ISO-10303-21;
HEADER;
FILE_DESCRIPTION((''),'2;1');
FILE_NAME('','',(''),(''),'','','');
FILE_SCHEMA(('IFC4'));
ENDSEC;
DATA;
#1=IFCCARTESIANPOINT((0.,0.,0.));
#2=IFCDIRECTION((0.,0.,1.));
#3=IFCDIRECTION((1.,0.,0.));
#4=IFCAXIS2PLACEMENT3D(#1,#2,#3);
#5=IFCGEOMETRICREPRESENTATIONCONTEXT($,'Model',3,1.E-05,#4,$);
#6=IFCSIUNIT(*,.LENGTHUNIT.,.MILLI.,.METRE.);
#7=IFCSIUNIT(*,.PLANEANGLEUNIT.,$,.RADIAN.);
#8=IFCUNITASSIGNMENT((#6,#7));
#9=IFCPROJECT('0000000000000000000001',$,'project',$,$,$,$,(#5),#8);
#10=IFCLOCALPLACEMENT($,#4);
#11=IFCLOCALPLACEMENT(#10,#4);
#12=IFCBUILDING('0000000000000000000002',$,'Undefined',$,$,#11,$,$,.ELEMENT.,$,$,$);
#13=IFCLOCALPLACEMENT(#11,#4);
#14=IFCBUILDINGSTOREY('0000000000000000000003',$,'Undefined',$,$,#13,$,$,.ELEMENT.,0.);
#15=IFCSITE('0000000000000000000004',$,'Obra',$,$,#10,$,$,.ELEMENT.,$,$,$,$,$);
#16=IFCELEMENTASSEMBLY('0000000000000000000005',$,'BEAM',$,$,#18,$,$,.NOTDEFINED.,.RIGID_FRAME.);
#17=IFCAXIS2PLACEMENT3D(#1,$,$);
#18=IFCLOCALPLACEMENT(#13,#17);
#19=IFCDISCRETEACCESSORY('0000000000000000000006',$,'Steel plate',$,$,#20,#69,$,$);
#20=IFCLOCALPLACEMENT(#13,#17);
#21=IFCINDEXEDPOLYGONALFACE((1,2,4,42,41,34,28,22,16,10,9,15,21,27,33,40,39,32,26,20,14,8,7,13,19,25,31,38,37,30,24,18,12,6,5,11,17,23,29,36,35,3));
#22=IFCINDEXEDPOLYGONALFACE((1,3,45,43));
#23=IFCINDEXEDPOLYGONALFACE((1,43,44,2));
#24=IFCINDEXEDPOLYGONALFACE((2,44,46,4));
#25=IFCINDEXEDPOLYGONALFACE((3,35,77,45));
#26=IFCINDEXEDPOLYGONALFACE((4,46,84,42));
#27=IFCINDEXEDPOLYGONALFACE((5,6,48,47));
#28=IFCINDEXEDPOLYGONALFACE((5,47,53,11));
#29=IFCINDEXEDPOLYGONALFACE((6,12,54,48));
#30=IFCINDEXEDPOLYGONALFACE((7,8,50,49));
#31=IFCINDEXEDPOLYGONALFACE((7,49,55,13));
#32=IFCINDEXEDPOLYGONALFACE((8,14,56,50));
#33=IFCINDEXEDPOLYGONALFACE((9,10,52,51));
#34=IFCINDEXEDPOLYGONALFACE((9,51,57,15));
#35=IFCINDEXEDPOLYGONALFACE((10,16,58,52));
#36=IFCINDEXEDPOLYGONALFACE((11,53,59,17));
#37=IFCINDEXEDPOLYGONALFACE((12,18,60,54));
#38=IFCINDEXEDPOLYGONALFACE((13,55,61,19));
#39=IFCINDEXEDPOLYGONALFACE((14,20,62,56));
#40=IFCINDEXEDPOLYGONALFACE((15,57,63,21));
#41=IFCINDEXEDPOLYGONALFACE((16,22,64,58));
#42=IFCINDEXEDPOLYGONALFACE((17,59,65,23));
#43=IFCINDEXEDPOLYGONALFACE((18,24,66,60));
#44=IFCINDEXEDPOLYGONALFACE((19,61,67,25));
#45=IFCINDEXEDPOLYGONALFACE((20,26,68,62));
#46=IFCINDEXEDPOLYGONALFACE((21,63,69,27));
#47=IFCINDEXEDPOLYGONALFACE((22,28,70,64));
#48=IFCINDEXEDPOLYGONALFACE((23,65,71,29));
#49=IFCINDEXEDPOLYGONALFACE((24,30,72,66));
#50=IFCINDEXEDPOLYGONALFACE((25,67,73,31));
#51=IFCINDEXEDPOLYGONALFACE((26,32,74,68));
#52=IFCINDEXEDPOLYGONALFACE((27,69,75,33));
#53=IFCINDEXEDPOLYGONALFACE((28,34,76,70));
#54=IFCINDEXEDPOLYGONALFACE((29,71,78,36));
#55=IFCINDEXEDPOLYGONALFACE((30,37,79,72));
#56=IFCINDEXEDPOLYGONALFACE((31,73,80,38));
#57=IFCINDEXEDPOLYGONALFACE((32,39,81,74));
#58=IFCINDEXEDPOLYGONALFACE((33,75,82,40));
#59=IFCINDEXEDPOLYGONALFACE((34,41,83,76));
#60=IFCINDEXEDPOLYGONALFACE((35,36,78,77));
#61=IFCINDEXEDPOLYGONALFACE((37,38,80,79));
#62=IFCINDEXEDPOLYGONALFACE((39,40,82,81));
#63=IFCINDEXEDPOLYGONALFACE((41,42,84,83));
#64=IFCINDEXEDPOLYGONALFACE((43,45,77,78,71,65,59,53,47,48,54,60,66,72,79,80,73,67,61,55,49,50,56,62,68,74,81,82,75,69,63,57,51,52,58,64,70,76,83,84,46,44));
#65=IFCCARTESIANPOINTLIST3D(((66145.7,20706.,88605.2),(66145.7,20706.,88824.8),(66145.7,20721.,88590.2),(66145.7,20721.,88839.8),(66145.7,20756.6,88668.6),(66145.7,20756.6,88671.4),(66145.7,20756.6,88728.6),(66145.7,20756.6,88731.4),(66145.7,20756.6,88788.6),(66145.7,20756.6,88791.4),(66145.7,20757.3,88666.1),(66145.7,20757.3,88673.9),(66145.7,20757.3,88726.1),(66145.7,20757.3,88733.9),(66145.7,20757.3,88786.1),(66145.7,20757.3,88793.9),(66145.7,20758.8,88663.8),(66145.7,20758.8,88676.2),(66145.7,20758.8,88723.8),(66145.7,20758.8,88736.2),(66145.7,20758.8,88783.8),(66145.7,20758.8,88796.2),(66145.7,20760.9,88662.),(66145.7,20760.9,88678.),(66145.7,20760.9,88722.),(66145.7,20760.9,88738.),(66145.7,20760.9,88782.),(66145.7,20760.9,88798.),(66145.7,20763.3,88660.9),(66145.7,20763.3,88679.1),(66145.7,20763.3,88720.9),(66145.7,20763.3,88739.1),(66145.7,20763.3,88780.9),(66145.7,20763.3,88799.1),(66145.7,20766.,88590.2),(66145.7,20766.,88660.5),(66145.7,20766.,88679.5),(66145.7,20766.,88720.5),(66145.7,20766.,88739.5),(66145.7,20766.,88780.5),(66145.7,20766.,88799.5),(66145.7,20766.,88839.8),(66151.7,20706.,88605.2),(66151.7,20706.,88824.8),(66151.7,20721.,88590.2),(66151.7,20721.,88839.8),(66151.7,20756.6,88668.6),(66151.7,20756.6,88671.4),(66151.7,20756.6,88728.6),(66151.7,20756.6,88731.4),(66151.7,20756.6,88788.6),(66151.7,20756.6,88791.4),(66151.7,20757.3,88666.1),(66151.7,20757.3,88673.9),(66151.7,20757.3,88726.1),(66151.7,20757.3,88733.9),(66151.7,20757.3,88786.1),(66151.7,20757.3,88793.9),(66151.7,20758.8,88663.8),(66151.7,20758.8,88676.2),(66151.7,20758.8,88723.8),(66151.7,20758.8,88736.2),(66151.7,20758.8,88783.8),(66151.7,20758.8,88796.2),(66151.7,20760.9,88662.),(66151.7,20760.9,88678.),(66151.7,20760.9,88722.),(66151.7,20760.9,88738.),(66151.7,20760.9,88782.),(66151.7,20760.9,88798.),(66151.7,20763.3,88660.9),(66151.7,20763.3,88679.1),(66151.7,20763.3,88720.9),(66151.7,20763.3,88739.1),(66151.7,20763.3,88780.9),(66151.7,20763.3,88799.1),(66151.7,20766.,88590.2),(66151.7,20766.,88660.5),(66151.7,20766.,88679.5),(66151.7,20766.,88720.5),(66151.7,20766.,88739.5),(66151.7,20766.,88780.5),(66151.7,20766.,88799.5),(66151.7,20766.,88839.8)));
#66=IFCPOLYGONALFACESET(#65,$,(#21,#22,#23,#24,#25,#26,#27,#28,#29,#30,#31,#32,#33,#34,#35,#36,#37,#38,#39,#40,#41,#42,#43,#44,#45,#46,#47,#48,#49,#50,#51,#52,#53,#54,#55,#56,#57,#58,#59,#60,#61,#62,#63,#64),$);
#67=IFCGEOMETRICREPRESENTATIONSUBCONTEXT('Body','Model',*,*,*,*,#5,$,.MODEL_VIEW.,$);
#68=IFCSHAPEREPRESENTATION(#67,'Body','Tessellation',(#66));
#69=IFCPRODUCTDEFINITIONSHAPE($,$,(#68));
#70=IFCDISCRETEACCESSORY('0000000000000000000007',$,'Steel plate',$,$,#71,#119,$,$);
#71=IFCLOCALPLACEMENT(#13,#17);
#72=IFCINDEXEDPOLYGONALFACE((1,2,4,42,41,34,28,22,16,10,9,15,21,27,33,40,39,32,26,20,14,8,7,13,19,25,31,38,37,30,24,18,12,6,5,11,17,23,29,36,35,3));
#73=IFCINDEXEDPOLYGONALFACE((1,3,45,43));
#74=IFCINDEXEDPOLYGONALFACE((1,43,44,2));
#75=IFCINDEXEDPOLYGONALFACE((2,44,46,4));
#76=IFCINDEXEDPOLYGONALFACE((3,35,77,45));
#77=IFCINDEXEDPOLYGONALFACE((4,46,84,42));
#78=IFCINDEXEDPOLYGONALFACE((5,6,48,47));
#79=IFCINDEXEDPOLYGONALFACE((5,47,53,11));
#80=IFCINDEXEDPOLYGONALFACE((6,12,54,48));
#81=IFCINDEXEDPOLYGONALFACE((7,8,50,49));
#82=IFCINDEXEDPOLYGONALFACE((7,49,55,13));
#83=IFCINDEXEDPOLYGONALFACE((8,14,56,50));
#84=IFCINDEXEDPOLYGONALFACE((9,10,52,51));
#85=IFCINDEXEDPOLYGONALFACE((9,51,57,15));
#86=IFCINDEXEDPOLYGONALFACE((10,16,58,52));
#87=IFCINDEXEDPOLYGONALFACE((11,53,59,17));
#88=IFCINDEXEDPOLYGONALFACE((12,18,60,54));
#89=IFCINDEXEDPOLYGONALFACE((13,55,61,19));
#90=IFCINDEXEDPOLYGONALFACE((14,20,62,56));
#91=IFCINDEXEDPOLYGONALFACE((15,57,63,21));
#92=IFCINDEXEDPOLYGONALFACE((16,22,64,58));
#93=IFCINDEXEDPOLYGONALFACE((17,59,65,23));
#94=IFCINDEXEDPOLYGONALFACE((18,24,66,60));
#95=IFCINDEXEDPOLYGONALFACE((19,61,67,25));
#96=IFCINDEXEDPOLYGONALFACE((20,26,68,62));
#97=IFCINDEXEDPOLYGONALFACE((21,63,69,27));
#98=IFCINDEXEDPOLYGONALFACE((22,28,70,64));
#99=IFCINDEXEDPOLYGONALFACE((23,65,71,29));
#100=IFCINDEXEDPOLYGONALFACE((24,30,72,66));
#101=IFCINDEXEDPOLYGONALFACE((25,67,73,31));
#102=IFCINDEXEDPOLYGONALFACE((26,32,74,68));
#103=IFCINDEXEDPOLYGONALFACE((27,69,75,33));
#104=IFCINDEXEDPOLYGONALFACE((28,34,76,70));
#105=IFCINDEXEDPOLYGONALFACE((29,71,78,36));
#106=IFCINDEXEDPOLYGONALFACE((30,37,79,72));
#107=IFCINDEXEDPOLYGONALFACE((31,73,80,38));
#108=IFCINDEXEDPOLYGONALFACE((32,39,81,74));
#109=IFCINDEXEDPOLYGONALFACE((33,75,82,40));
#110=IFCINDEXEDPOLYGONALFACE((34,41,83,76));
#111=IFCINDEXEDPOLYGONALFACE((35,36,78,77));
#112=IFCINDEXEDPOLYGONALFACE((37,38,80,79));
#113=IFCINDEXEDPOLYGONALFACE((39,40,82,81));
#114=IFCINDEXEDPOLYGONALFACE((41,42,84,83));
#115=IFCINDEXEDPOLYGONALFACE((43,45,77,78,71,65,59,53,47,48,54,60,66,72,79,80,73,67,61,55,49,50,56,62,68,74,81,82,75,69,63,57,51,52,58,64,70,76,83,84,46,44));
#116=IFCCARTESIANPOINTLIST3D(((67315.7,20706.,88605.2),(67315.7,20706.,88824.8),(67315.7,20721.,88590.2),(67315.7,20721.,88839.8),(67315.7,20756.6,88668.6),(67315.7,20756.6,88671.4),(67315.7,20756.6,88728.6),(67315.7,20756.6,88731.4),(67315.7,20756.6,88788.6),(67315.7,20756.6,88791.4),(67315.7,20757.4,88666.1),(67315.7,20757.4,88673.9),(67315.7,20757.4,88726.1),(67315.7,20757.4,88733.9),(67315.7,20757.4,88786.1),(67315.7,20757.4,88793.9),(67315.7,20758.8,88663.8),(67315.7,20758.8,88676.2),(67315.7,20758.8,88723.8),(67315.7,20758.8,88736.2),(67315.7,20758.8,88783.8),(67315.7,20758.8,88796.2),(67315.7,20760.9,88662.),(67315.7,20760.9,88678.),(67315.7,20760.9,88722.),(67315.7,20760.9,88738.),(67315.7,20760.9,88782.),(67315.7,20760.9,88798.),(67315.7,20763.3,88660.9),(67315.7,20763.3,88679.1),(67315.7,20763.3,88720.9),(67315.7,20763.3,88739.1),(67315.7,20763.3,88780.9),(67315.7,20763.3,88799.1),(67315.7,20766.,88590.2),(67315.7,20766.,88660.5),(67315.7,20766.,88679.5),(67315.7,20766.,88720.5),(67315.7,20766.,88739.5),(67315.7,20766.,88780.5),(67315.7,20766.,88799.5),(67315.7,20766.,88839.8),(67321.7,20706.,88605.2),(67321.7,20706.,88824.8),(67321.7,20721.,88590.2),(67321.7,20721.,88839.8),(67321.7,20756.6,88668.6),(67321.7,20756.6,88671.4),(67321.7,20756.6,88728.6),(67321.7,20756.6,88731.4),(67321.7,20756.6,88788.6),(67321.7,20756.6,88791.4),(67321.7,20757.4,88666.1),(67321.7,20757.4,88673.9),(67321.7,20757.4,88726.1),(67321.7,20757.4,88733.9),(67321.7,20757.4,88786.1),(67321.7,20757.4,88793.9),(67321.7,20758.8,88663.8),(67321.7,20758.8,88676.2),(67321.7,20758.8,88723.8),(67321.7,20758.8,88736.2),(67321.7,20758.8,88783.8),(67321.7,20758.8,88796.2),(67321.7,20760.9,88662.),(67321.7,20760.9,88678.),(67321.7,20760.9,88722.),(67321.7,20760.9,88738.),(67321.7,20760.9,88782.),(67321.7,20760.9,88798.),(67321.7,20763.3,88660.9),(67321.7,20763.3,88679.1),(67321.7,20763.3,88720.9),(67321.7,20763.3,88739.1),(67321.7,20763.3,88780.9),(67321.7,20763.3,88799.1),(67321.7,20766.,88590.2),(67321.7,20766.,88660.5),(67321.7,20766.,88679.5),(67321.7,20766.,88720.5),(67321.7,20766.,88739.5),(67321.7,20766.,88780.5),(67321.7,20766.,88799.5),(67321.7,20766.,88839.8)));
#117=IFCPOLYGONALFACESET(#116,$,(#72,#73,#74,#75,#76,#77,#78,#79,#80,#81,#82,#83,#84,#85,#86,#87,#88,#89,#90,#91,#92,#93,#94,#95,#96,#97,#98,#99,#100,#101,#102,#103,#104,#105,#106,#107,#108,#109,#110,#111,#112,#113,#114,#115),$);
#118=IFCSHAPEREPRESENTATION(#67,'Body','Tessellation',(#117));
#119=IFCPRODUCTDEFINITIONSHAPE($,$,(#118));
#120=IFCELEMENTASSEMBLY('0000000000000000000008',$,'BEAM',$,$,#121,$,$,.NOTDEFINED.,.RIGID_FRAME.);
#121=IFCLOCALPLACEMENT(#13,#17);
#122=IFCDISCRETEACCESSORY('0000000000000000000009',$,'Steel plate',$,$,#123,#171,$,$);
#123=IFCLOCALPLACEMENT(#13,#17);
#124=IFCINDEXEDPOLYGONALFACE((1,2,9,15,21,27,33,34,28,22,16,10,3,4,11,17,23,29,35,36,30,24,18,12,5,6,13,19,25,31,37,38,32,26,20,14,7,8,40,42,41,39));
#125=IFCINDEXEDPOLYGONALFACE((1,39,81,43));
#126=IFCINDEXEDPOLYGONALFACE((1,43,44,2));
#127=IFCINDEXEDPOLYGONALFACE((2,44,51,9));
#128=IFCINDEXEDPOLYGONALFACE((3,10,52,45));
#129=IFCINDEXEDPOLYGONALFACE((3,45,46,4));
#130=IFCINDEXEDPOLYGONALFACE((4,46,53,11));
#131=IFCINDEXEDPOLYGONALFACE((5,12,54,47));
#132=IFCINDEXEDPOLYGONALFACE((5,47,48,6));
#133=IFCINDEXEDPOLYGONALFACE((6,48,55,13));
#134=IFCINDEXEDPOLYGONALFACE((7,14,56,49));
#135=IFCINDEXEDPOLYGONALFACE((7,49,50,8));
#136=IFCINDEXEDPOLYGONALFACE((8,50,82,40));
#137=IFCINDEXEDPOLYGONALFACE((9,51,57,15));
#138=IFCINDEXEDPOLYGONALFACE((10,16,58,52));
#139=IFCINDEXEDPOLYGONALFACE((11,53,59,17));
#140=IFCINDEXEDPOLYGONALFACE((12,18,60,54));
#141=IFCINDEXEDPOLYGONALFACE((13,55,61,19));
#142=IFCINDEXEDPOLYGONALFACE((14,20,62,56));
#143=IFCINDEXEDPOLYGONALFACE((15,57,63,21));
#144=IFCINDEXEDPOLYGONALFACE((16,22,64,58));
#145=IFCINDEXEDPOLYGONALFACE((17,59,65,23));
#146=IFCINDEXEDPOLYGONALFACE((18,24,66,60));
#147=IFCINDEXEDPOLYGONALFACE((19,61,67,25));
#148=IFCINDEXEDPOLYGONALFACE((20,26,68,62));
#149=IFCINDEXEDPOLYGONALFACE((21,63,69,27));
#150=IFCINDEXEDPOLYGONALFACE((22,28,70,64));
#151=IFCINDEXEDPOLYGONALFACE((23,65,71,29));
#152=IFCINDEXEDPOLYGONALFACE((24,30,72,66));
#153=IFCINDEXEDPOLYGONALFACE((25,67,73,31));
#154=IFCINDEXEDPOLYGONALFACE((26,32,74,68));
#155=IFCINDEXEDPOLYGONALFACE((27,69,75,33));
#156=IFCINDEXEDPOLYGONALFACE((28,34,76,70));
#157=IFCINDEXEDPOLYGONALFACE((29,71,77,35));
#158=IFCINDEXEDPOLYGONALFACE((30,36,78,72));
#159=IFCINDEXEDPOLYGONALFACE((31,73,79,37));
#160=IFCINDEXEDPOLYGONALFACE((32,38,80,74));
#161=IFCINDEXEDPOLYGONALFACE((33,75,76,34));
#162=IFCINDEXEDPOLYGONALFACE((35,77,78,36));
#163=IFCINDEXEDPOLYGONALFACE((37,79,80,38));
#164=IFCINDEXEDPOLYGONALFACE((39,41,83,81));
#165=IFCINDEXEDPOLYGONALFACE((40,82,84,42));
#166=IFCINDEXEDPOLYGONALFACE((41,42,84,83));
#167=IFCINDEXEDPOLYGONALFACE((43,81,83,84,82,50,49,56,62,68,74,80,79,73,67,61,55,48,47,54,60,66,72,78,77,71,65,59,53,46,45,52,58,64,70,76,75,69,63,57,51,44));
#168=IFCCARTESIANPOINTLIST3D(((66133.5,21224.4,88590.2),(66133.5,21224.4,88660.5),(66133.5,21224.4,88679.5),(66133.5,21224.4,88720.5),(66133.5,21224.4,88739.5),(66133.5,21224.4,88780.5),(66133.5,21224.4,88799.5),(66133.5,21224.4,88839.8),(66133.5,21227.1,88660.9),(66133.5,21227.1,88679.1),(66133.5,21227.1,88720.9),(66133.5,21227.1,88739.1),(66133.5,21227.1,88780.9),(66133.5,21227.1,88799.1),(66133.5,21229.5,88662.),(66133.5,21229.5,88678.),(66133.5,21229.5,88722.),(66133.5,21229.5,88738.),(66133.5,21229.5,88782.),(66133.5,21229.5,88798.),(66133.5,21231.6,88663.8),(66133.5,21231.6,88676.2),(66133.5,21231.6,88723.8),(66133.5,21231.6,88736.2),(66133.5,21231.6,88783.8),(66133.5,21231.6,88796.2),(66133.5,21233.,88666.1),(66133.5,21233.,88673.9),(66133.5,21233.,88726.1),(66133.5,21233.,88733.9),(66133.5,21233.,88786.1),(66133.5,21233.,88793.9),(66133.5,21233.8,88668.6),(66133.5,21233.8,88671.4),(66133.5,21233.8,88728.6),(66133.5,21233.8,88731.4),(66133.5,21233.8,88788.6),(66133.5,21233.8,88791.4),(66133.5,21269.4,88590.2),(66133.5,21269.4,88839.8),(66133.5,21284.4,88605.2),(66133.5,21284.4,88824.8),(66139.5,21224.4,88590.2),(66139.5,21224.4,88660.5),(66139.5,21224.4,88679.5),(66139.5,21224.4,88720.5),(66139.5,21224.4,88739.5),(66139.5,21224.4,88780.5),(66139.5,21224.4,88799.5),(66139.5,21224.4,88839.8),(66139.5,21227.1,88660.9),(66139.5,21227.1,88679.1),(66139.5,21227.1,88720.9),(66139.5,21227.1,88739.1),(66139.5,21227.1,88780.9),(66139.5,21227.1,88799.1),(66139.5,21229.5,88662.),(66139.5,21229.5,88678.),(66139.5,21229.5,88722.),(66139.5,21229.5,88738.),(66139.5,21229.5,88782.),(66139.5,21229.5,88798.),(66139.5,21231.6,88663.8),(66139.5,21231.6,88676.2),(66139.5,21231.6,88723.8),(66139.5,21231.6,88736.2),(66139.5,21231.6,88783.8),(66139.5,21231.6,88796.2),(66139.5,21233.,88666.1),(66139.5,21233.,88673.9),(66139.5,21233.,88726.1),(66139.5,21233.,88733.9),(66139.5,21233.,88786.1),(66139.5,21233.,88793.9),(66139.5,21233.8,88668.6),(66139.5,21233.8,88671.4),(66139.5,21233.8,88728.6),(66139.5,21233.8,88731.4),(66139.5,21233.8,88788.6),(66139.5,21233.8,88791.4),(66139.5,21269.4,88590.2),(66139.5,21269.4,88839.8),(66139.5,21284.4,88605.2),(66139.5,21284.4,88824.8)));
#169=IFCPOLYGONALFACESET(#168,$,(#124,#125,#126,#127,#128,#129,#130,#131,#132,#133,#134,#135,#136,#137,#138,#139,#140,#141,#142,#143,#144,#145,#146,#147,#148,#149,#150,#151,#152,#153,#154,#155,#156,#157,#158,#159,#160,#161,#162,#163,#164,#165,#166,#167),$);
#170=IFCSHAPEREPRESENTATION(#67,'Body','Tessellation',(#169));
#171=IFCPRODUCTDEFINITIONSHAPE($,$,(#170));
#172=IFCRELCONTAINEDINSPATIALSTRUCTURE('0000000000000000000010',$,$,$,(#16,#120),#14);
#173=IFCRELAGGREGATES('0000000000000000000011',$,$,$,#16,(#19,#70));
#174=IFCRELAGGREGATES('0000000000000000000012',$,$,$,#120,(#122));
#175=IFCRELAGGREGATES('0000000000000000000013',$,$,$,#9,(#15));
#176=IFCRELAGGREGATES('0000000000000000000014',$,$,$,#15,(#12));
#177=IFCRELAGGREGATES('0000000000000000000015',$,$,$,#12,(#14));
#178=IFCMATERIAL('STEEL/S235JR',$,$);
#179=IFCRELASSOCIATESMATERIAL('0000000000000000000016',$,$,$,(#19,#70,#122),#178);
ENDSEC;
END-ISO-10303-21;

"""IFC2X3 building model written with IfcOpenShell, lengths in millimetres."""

from ifc_helpers import new_model, si_unit, frame, origin_with_axes, origin_2d_with_axis, place, context, subcontext, project, spatial, polyline, circle, outline, extrude, source, transform, mapped, material, element, aggregate, save


model = new_model("IFC2X3")

# Units and contexts
model_context = context("Model", 3, precision=1e-05, world=origin_with_axes())
body_context = subcontext(model_context, "Body", "Model", "MODEL_VIEW")
ifc_project = project(units=[si_unit("LENGTHUNIT", "METRE", prefix="MILLI"), si_unit("PLANEANGLEUNIT", "RADIAN")], contexts=[model_context])

# Site, building, storey
site_placement = place(None, origin_with_axes())
site = spatial("IfcSite", under=ifc_project, at=site_placement, Name="Obra", CompositionType="ELEMENT")
building_placement = place(site_placement, origin_with_axes())
building = spatial("IfcBuilding", under=site, at=building_placement, Name="Undefined", CompositionType="ELEMENT")
storey_placement = place(building_placement, origin_with_axes())
storey = spatial("IfcBuildingStorey", under=building, at=storey_placement, Name="Undefined", CompositionType="ELEMENT", Elevation=0.0)

# Shared definitions
ifc_material = material(Name="STEEL/S235JR")

# Element assemblies, discrete accessories, openings
assembly_1_placement = place(storey_placement, origin_with_axes())
assembly_1 = element("IfcElementAssembly", 1, at=assembly_1_placement, inside=storey, Name="BEAM", AssemblyPlace="NOTDEFINED", PredefinedType="RIGID_FRAME")
discrete_accessory_1_placement = place(assembly_1_placement, frame((66148.7, 20766.0, 88590.2), z_axis=(-1.0, -0.000002, 0.0), x_axis=(0.000002, -1.0, 0.0)))
discrete_accessory_1 = element("IfcDiscreteAccessory", 2, at=discrete_accessory_1_placement, material=ifc_material, Name="Steel plate", context=body_context, shape_type="SweptSolid", body=[
    extrude(outline(polyline([(0.0, 0.0), (45.0, 0.0), (60.0, 15.0), (60.0, 234.6), (45.0, 249.6), (0.0, 249.6), (0.0, 0.0)])), frame((0.0, 0.0, -3.0), z_axis=(0.0, 0.0, 1.0), x_axis=(1.0, 0.0, 0.0)), (0.0, 0.0, 1.0), 6.0),
])
shared_shape_1 = source(origin_with_axes(), body_context, "Body", "SweptSolid", [
    extrude(circle(Radius=9.5, at=origin_2d_with_axis()), frame((0.0, -9.2, 0.0), z_axis=(0.0, 1.0, 0.0), x_axis=(1.0, 0.0, 0.0)), (0.0, 0.0, 1.0), 6.2),
])
opening_1_placement = place(assembly_1_placement, frame((66142.6, 20716.0, 88850.0), z_axis=(-0.000002, 1.0, 0.0), x_axis=(0.0, 0.0, -1.0)))
element("IfcOpeningElement", 3, at=opening_1_placement, cuts=discrete_accessory_1, ObjectType="Opening", context=body_context, shape_type="MappedRepresentation", body=[
    mapped(shared_shape_1, transform((60.0, 0.0, 50.0))),
    mapped(shared_shape_1, transform((120.0, 0.0, 50.0))),
    mapped(shared_shape_1, transform((180.0, 0.0, 50.0))),
])
discrete_accessory_2_placement = place(assembly_1_placement, frame((67318.7, 20766.0, 88590.2), z_axis=(-1.0, -0.000002, 0.0), x_axis=(0.000002, -1.0, 0.0)))
discrete_accessory_2 = element("IfcDiscreteAccessory", 4, at=discrete_accessory_2_placement, material=ifc_material, Name="Steel plate", context=body_context, shape_type="SweptSolid", body=[
    extrude(outline(polyline([(0.0, 0.0), (45.0, 0.0), (60.0, 15.0), (60.0, 234.6), (45.0, 249.6), (0.0, 249.6), (0.0, 0.0)])), frame((0.0, 0.0, -3.0), z_axis=(0.0, 0.0, 1.0), x_axis=(1.0, 0.0, 0.0)), (0.0, 0.0, 1.0), 6.0),
])
opening_2_placement = place(assembly_1_placement, frame((67312.6, 20716.0, 88850.0), z_axis=(-0.000002, 1.0, 0.0), x_axis=(0.0, 0.0, -1.0)))
element("IfcOpeningElement", 5, at=opening_2_placement, cuts=discrete_accessory_2, ObjectType="Opening", context=body_context, shape_type="MappedRepresentation", body=[
    mapped(shared_shape_1, transform((60.0, 0.0, 50.0))),
    mapped(shared_shape_1, transform((120.0, 0.0, 50.0))),
    mapped(shared_shape_1, transform((180.0, 0.0, 50.0))),
])
aggregate(assembly_1, [discrete_accessory_1, discrete_accessory_2])
assembly_2_placement = place(storey_placement, origin_with_axes())
assembly_2 = element("IfcElementAssembly", 6, at=assembly_2_placement, inside=storey, Name="BEAM", AssemblyPlace="NOTDEFINED", PredefinedType="RIGID_FRAME")
discrete_accessory_3_placement = place(assembly_2_placement, frame((66136.5, 21224.4, 88590.2), z_axis=(1.0, 0.000001, 0.0), x_axis=(-0.000002, 1.0, 0.0)))
discrete_accessory_3 = element("IfcDiscreteAccessory", 7, at=discrete_accessory_3_placement, material=ifc_material, Name="Steel plate", context=body_context, shape_type="SweptSolid", body=[
    extrude(outline(polyline([(0.0, 0.0), (45.0, 0.0), (60.0, 15.0), (60.0, 234.6), (45.0, 249.6), (0.0, 249.6), (0.0, 0.0)])), frame((0.0, 0.0, -3.0), z_axis=(0.0, 0.0, 1.0), x_axis=(1.0, 0.0, 0.0)), (0.0, 0.0, 1.0), 6.0),
])
opening_3_placement = place(assembly_2_placement, frame((66142.6, 21274.4, 88850.0), z_axis=(0.000002, -1.0, 0.0), x_axis=(0.0, 0.0, -1.0)))
element("IfcOpeningElement", 8, at=opening_3_placement, cuts=discrete_accessory_3, ObjectType="Opening", context=body_context, shape_type="MappedRepresentation", body=[
    mapped(shared_shape_1, transform((60.0, 0.0, 50.0))),
    mapped(shared_shape_1, transform((120.0, 0.0, 50.0))),
    mapped(shared_shape_1, transform((180.0, 0.0, 50.0))),
])
aggregate(assembly_2, [discrete_accessory_3])

save(model, "model.ifc")
